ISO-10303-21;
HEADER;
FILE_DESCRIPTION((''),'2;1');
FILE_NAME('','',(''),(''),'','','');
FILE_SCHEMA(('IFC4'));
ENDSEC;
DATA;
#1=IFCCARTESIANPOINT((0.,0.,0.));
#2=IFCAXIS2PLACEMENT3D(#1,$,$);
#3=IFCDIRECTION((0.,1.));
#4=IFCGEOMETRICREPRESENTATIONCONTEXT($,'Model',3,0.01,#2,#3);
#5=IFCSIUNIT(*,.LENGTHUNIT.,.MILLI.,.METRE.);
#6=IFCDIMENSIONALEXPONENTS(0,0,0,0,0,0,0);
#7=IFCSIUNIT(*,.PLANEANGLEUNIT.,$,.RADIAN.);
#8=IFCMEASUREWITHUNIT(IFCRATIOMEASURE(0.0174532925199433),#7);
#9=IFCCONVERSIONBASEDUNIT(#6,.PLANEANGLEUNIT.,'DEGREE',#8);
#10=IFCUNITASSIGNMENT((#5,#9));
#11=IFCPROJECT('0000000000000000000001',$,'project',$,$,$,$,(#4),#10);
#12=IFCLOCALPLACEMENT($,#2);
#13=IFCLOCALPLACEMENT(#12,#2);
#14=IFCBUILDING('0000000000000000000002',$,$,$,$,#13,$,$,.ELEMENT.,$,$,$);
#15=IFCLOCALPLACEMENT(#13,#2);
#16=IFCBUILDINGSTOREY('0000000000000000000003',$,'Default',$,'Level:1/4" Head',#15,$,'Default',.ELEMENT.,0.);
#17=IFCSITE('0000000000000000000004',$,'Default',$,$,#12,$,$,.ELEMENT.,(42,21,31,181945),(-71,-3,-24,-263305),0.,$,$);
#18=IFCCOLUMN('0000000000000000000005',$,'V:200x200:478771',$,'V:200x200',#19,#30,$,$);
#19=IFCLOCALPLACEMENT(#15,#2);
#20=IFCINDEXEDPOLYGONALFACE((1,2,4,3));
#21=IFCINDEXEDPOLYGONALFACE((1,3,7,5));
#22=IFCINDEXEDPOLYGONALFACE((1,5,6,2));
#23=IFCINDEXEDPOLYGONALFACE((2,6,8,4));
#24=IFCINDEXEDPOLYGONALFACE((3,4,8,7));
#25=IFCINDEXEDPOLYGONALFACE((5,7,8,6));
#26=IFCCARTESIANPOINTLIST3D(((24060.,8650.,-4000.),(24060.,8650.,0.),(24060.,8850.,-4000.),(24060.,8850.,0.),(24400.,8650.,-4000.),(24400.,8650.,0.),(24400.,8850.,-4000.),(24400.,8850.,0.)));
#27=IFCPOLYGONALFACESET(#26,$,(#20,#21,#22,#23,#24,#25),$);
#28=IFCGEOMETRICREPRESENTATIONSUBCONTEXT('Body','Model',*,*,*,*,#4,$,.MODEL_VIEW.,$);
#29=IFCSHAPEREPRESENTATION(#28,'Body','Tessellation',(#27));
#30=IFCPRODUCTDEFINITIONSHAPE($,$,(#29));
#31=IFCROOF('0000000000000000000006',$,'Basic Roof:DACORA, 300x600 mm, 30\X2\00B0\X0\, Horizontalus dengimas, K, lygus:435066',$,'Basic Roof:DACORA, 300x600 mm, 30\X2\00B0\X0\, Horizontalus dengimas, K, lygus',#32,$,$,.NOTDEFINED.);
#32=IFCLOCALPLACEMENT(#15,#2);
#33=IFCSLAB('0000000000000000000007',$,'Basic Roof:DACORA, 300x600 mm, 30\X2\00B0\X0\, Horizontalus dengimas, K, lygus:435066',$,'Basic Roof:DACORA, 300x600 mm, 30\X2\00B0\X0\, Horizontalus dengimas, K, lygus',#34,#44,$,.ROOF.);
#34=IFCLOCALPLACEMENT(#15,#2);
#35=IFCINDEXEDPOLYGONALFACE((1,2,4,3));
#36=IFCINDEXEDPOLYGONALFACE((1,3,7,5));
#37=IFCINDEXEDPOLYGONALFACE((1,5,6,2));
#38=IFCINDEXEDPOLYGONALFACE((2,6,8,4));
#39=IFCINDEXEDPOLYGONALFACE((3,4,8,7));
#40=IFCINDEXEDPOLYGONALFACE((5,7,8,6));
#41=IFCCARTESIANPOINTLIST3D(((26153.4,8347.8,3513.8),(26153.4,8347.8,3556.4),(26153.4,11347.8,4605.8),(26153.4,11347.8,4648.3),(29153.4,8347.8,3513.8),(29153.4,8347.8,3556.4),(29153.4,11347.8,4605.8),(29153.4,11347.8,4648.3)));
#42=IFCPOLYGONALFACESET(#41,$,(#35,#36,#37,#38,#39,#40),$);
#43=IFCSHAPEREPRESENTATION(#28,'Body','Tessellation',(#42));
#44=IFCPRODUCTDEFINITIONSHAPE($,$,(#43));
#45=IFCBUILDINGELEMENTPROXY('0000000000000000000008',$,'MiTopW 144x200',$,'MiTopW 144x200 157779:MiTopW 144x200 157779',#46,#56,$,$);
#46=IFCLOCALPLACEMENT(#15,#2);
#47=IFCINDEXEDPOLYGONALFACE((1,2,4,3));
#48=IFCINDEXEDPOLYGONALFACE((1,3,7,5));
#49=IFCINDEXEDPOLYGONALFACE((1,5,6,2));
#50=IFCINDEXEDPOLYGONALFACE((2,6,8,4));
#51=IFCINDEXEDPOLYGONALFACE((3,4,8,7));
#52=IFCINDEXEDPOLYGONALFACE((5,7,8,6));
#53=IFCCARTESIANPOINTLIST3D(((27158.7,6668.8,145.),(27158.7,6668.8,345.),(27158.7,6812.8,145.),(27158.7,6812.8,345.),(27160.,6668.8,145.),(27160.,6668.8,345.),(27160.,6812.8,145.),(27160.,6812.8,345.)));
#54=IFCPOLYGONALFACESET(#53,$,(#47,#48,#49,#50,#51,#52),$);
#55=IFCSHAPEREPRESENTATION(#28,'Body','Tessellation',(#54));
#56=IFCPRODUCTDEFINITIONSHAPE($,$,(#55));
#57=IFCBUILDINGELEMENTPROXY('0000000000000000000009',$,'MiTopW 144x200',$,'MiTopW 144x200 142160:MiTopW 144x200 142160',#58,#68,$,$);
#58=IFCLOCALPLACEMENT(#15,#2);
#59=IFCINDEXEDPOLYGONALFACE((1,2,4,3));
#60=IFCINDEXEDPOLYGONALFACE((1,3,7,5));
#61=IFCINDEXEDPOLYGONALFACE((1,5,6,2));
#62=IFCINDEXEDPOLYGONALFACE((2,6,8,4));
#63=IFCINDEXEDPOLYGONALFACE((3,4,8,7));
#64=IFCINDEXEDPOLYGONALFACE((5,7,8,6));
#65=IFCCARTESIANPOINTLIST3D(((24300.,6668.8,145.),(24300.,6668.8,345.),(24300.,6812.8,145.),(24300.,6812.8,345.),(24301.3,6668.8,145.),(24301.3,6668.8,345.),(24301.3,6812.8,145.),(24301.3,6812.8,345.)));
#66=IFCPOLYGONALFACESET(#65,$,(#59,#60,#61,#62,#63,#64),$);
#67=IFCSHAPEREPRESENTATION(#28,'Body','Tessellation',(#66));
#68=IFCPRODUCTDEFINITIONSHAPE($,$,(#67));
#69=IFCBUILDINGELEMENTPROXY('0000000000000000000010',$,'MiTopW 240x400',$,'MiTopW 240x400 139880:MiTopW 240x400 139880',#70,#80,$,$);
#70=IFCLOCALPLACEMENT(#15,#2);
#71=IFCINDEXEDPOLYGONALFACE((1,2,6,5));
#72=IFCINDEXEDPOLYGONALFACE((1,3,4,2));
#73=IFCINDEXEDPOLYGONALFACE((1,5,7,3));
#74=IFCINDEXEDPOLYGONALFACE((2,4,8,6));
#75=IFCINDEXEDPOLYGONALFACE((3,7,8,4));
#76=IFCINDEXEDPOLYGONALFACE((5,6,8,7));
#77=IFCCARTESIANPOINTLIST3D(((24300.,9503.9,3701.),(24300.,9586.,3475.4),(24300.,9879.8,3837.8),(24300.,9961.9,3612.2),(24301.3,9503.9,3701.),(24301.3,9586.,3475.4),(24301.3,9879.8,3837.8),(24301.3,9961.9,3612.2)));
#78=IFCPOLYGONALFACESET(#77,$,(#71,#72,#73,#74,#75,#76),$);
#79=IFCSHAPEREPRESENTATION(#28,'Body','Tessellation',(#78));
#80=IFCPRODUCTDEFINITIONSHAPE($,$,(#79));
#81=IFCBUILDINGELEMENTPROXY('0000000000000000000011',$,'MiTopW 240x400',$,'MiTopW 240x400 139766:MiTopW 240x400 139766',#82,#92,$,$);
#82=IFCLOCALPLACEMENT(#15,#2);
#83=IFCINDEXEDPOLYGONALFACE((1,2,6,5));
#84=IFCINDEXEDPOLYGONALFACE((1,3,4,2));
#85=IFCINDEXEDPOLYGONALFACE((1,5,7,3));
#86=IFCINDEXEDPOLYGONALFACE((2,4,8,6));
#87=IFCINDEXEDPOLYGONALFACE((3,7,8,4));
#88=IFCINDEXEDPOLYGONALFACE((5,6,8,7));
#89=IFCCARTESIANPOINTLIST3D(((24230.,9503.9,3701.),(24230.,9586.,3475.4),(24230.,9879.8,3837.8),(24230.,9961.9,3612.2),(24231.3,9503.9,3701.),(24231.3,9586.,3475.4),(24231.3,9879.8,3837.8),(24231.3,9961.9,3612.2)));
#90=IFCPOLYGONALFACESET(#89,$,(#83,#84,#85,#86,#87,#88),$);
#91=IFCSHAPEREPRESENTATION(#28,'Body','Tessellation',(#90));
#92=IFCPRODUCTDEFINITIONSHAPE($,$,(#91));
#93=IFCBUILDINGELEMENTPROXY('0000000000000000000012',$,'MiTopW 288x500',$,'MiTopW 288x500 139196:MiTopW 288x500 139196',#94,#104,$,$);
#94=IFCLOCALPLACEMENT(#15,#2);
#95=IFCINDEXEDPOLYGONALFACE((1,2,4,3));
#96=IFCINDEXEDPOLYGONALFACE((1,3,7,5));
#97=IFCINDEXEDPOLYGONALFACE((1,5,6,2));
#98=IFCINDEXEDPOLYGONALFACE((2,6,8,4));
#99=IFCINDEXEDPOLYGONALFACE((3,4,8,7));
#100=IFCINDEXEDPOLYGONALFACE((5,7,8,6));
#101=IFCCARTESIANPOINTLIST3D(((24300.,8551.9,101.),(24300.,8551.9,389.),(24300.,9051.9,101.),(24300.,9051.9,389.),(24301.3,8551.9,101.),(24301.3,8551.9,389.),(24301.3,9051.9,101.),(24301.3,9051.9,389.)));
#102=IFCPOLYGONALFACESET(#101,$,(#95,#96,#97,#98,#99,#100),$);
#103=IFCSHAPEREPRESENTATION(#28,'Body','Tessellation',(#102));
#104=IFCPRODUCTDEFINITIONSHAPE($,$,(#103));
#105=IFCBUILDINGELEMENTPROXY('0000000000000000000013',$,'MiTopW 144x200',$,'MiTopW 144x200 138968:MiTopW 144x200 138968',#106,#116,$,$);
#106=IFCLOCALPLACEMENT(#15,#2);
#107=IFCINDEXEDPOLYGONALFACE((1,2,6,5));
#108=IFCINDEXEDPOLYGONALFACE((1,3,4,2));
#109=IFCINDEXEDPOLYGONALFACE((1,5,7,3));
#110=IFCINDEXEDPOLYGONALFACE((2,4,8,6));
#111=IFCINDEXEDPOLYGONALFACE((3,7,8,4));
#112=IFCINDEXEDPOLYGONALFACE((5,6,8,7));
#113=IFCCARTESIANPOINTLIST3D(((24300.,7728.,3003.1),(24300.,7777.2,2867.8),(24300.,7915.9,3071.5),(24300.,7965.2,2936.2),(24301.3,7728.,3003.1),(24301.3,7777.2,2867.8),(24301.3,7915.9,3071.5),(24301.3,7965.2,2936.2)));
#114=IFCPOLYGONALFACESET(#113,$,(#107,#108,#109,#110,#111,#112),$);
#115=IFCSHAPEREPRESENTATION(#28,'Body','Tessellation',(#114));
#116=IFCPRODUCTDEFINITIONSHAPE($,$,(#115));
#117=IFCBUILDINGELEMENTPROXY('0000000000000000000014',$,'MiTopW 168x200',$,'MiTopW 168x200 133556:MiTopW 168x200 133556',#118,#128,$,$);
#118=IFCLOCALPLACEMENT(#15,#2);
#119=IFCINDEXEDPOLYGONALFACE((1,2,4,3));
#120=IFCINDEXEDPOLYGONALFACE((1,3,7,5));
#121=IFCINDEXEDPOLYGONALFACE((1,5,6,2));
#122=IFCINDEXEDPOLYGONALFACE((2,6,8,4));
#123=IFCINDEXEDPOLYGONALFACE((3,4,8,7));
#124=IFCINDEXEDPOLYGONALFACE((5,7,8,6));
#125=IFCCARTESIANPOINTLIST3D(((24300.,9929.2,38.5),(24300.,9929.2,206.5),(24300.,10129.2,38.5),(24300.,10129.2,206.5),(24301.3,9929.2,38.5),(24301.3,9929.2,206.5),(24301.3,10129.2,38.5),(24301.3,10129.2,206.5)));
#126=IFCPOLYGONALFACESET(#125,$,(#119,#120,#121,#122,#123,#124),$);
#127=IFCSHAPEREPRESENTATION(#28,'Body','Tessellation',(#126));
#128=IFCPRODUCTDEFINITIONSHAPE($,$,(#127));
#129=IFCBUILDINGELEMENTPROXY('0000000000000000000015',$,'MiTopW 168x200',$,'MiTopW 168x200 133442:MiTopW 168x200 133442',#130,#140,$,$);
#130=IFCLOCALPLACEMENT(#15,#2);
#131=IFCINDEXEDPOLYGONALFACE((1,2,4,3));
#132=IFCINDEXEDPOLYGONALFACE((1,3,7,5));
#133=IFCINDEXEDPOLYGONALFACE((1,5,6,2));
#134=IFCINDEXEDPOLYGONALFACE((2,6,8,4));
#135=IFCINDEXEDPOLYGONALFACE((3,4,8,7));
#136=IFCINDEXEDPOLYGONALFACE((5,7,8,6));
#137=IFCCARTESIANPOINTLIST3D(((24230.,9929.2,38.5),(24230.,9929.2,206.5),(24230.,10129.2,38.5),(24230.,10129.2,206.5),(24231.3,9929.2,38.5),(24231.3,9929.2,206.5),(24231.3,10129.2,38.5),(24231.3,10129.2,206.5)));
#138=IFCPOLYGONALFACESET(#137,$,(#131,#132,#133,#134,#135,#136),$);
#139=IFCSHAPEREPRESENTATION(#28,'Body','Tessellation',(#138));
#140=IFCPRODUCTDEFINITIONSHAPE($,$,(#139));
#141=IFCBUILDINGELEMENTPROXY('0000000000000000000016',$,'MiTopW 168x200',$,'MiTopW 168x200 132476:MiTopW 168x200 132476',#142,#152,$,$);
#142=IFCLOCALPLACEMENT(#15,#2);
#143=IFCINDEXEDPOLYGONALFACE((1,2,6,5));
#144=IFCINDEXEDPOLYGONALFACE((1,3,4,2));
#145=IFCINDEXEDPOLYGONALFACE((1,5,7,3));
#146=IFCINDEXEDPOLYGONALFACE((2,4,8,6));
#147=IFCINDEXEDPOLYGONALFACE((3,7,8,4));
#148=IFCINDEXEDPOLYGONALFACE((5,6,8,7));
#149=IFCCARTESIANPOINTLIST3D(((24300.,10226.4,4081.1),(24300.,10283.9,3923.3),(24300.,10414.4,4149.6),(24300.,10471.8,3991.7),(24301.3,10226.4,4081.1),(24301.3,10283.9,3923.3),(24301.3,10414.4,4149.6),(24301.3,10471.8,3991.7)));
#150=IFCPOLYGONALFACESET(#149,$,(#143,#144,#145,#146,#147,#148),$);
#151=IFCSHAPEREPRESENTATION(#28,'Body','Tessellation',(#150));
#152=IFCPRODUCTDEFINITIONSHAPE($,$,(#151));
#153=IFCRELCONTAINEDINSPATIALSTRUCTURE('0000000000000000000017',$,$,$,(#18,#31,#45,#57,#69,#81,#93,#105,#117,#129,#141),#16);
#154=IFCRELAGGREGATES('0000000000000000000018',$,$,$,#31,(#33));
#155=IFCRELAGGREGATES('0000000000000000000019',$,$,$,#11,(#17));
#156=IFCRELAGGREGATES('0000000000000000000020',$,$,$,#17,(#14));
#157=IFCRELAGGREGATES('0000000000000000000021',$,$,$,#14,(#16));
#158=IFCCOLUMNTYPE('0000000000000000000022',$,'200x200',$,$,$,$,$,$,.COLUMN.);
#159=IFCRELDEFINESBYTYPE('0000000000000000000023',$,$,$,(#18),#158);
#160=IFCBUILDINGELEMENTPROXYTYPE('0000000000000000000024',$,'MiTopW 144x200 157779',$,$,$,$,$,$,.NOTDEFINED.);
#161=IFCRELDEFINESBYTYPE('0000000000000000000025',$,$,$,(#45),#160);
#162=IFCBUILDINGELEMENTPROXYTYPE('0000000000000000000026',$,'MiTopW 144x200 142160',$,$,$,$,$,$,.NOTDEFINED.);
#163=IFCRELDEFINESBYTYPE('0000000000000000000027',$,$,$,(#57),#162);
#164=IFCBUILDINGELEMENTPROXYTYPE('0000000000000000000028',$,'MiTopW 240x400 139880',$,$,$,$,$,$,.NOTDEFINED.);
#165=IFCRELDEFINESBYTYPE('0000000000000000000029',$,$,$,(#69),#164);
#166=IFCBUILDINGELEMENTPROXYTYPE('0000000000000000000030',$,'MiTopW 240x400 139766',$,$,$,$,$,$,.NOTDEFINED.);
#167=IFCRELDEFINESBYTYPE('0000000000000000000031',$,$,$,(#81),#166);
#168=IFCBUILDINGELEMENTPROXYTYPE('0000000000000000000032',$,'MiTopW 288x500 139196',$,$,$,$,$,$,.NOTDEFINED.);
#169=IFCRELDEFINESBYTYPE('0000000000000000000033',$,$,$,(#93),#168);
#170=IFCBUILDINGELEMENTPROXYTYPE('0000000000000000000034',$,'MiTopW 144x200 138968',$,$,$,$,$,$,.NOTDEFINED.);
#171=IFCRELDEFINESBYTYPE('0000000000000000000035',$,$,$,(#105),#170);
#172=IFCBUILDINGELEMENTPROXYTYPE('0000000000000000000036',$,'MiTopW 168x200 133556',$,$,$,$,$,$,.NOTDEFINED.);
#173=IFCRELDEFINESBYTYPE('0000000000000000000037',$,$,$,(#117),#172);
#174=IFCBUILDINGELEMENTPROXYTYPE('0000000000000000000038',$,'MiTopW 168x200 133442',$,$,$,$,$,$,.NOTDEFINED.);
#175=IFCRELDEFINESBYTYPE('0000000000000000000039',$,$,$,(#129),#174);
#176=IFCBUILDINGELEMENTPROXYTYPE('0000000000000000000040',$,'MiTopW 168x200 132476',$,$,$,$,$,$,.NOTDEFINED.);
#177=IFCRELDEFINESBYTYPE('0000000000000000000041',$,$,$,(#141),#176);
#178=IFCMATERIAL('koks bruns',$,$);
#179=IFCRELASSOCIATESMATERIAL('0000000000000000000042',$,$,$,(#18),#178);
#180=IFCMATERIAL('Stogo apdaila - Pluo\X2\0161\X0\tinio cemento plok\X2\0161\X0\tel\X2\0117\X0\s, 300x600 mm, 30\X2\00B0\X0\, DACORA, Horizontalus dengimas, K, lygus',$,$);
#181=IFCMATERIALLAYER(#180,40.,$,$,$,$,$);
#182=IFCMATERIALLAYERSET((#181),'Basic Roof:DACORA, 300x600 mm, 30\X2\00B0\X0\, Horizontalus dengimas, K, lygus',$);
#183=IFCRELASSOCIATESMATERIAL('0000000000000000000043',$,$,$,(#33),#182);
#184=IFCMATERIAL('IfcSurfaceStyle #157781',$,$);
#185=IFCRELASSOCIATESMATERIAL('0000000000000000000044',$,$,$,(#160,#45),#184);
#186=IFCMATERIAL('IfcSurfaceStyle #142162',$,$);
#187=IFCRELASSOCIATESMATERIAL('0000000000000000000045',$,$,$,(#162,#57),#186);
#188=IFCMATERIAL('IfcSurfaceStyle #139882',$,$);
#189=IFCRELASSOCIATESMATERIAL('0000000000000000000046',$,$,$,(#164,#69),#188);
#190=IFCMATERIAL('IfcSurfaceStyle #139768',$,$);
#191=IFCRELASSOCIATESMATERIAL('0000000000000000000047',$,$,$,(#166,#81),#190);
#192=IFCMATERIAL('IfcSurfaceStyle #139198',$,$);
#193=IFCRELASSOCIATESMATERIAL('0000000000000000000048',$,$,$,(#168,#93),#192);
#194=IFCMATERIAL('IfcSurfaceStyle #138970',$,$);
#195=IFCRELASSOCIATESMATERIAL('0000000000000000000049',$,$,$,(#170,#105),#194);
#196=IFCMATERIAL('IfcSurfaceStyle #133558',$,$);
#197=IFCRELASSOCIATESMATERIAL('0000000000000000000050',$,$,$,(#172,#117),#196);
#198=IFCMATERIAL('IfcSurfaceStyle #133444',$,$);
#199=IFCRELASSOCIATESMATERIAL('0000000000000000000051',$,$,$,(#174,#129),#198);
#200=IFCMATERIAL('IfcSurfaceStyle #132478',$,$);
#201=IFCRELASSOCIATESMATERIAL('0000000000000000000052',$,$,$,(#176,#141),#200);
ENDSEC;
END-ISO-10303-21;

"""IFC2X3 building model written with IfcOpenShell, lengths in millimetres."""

from ifc_helpers import new_model, entity, si_unit, converted_unit, direction, frame, frame_2d, origin, origin_2d_with_axis, place, context, subcontext, project, spatial, polyline, rectangle, outline, extrude, source, transform, mapped, material, layer, layer_set, type_object, type_shapes, element, aggregate, save


model = new_model("IFC2X3")

# Units and contexts
model_context = context("Model", 3, precision=0.01, world=origin(), true_north=direction((0.0, 1.0)))
body_context = subcontext(model_context, "Body", "Model", "MODEL_VIEW")
ifc_project = project(units=[si_unit("LENGTHUNIT", "METRE", prefix="MILLI"), converted_unit("PLANEANGLEUNIT", "DEGREE", entity("IfcRatioMeasure", 0.0174532925199433), si_unit("PLANEANGLEUNIT", "RADIAN"), dimensions=[0, 0, 0, 0, 0, 0, 0])], contexts=[model_context])

# Site, building, storey
site_placement = place(None, origin())
site = spatial("IfcSite", under=ifc_project, at=site_placement, Name="Default", CompositionType="ELEMENT", RefLatitude=(42, 21, 31, 181945), RefLongitude=(-71, -3, -24, -263305), RefElevation=0.0)
building_placement = place(site_placement, origin())
building = spatial("IfcBuilding", under=site, at=building_placement, CompositionType="ELEMENT")
storey_placement = place(building_placement, origin())
storey = spatial("IfcBuildingStorey", under=building, at=storey_placement, Name="Default", ObjectType="Level:1/4\" Head", LongName="Default", CompositionType="ELEMENT", Elevation=0.0)

# Column
ifc_material_1 = material(Name="koks bruns")
column_type_1 = type_object("IfcColumnType", Name="200x200", PredefinedType="COLUMN")
shared_shape_1 = source(origin(), body_context, "Body", "SweptSolid", [
    extrude(rectangle(XDim=340.0, YDim=200.0, at=origin_2d_with_axis()), frame((100.0, 280.0, -4000.0), z_axis=(0.0, 0.0, 1.0), x_axis=(0.0, -1.0, 0.0)), (0.0, 0.0, 1.0), 4000.0),
])
type_shapes(column_type_1, [shared_shape_1])
column_placement = place(storey_placement, frame((24510.0, 8650.0, 0.0), z_axis=(0.0, 0.0, 1.0), x_axis=(0.0, 1.0, 0.0)))
element("IfcColumn", 1, at=column_placement, inside=storey, type_object=column_type_1, material=ifc_material_1, Name="V:200x200:478771", ObjectType="V:200x200", context=body_context, shape_type="MappedRepresentation", body=[
    mapped(shared_shape_1, transform((0.0, 0.0, 0.0), scale=1.0)),
])

# Roof, slab
roof_placement = place(storey_placement, frame((26153.4, 8347.8, 3513.8)))
roof = element("IfcRoof", 2, at=roof_placement, inside=storey, Name="Basic Roof:DACORA, 300x600 mm, 30°, Horizontalus dengimas, K, lygus:435066", ObjectType="Basic Roof:DACORA, 300x600 mm, 30°, Horizontalus dengimas, K, lygus", ShapeType="NOTDEFINED")
ifc_material_2 = material(Name="Stogo apdaila - Pluoštinio cemento plokštelės, 300x600 mm, 30°, DACORA, Horizontalus dengimas, K, lygus")
ifc_layer = layer(ifc_material_2, 40.0)
ifc_layer_set = layer_set([ifc_layer], Name="Basic Roof:DACORA, 300x600 mm, 30°, Horizontalus dengimas, K, lygus")
slab_placement = place(roof_placement, origin())
slab = element("IfcSlab", 3, at=slab_placement, material=ifc_layer_set, Name="Basic Roof:DACORA, 300x600 mm, 30°, Horizontalus dengimas, K, lygus:435066", ObjectType="Basic Roof:DACORA, 300x600 mm, 30°, Horizontalus dengimas, K, lygus", PredefinedType="ROOF", context=body_context, shape_type="SweptSolid", body=[
    extrude(rectangle(XDim=3192.5, YDim=3000.0, at=frame_2d((0.0, 0.0), x_axis=(0.0, -1.0))), frame((1500.0, 1500.0, 546.0), z_axis=(0.0, -0.34202, 0.939693), x_axis=(1.0, 0.0, 0.0)), (0.0, 0.34202, 0.939693), 42.6),
])
aggregate(roof, [slab])

# Building element proxies
ifc_material_3 = material(Name="IfcSurfaceStyle #157781")
building_element_proxy_type_1 = type_object("IfcBuildingElementProxyType", Name="MiTopW 144x200 157779", PredefinedType="NOTDEFINED", material=ifc_material_3)
shared_shape_2 = source(origin(), body_context, "Body", "SweptSolid", [
    extrude(rectangle(XDim=200.0, YDim=144.0, at=frame_2d((0.0, 0.0), x_axis=(1.0, 0.0))), frame((100.0, 72.0, 0.0), z_axis=(0.0, 0.0, 1.0), x_axis=(-1.0, 0.0, 0.0)), (0.0, 0.0, 1.0), 1.3),
])
type_shapes(building_element_proxy_type_1, [shared_shape_2])
proxy_1_placement = place(building_placement, frame((27160.0, 6668.8, 145.0), z_axis=(-1.0, 0.0, 0.0), x_axis=(0.0, 0.0, 1.0)))
element("IfcBuildingElementProxy", 4, at=proxy_1_placement, inside=storey, type_object=building_element_proxy_type_1, material=ifc_material_3, Name="MiTopW 144x200", ObjectType="MiTopW 144x200 157779:MiTopW 144x200 157779", context=body_context, shape_type="MappedRepresentation", body=[
    mapped(shared_shape_2, transform((0.0, 0.0, 0.0), scale=1.0)),
])
ifc_material_4 = material(Name="IfcSurfaceStyle #142162")
building_element_proxy_type_2 = type_object("IfcBuildingElementProxyType", Name="MiTopW 144x200 142160", PredefinedType="NOTDEFINED", material=ifc_material_4)
shared_shape_3 = source(origin(), body_context, "Body", "SweptSolid", [
    extrude(rectangle(XDim=200.0, YDim=144.0, at=frame_2d((0.0, 0.0), x_axis=(1.0, 0.0))), frame((100.0, 72.0, 0.0), z_axis=(0.0, 0.0, 1.0), x_axis=(-1.0, 0.0, 0.0)), (0.0, 0.0, 1.0), 1.3),
])
type_shapes(building_element_proxy_type_2, [shared_shape_3])
proxy_2_placement = place(building_placement, frame((24301.3, 6668.8, 145.0), z_axis=(-1.0, 0.0, 0.0), x_axis=(0.0, 0.0, 1.0)))
element("IfcBuildingElementProxy", 5, at=proxy_2_placement, inside=storey, type_object=building_element_proxy_type_2, material=ifc_material_4, Name="MiTopW 144x200", ObjectType="MiTopW 144x200 142160:MiTopW 144x200 142160", context=body_context, shape_type="MappedRepresentation", body=[
    mapped(shared_shape_3, transform((0.0, 0.0, 0.0), scale=1.0)),
])
ifc_material_5 = material(Name="IfcSurfaceStyle #139882")
building_element_proxy_type_3 = type_object("IfcBuildingElementProxyType", Name="MiTopW 240x400 139880", PredefinedType="NOTDEFINED", material=ifc_material_5)
shared_shape_4 = source(origin(), body_context, "Body", "SweptSolid", [
    extrude(outline(polyline([(-200.0, -120.0), (200.0, -120.0), (200.0, 120.0), (-200.0, 120.0), (-200.0, -120.0)])), frame((200.0, 120.0, 0.0), z_axis=(0.0, 0.0, 1.0), x_axis=(-1.0, 0.0, 0.0)), (0.0, 0.0, 1.0), 1.3),
])
type_shapes(building_element_proxy_type_3, [shared_shape_4])
proxy_3_placement = place(building_placement, frame((24301.3, 9961.9, 3612.2), z_axis=(-1.0, 0.0, 0.0), x_axis=(0.0, -0.939693, -0.34202)))
element("IfcBuildingElementProxy", 6, at=proxy_3_placement, inside=storey, type_object=building_element_proxy_type_3, material=ifc_material_5, Name="MiTopW 240x400", ObjectType="MiTopW 240x400 139880:MiTopW 240x400 139880", context=body_context, shape_type="MappedRepresentation", body=[
    mapped(shared_shape_4, transform((0.0, 0.0, 0.0), scale=1.0)),
])
ifc_material_6 = material(Name="IfcSurfaceStyle #139768")
building_element_proxy_type_4 = type_object("IfcBuildingElementProxyType", Name="MiTopW 240x400 139766", PredefinedType="NOTDEFINED", material=ifc_material_6)
shared_shape_5 = source(origin(), body_context, "Body", "SweptSolid", [
    extrude(outline(polyline([(-200.0, -120.0), (200.0, -120.0), (200.0, 120.0), (-200.0, 120.0), (-200.0, -120.0)])), frame((200.0, 120.0, 0.0), z_axis=(0.0, 0.0, 1.0), x_axis=(-1.0, 0.0, 0.0)), (0.0, 0.0, 1.0), 1.3),
])
type_shapes(building_element_proxy_type_4, [shared_shape_5])
proxy_4_placement = place(building_placement, frame((24231.3, 9961.9, 3612.2), z_axis=(-1.0, 0.0, 0.0), x_axis=(0.0, -0.939693, -0.34202)))
element("IfcBuildingElementProxy", 7, at=proxy_4_placement, inside=storey, type_object=building_element_proxy_type_4, material=ifc_material_6, Name="MiTopW 240x400", ObjectType="MiTopW 240x400 139766:MiTopW 240x400 139766", context=body_context, shape_type="MappedRepresentation", body=[
    mapped(shared_shape_5, transform((0.0, 0.0, 0.0), scale=1.0)),
])
ifc_material_7 = material(Name="IfcSurfaceStyle #139198")
building_element_proxy_type_5 = type_object("IfcBuildingElementProxyType", Name="MiTopW 288x500 139196", PredefinedType="NOTDEFINED", material=ifc_material_7)
shared_shape_6 = source(origin(), body_context, "Body", "SweptSolid", [
    extrude(rectangle(XDim=500.0, YDim=288.0, at=frame_2d((0.0, 0.0), x_axis=(1.0, 0.0))), frame((250.0, 144.0, 0.0), z_axis=(0.0, 0.0, 1.0), x_axis=(-1.0, 0.0, 0.0)), (0.0, 0.0, 1.0), 1.3),
])
type_shapes(building_element_proxy_type_5, [shared_shape_6])
proxy_5_placement = place(building_placement, frame((24301.3, 8551.9, 389.0), z_axis=(-1.0, 0.0, 0.0), x_axis=(0.0, 1.0, 0.0)))
element("IfcBuildingElementProxy", 8, at=proxy_5_placement, inside=storey, type_object=building_element_proxy_type_5, material=ifc_material_7, Name="MiTopW 288x500", ObjectType="MiTopW 288x500 139196:MiTopW 288x500 139196", context=body_context, shape_type="MappedRepresentation", body=[
    mapped(shared_shape_6, transform((0.0, 0.0, 0.0), scale=1.0)),
])
ifc_material_8 = material(Name="IfcSurfaceStyle #138970")
building_element_proxy_type_6 = type_object("IfcBuildingElementProxyType", Name="MiTopW 144x200 138968", PredefinedType="NOTDEFINED", material=ifc_material_8)
shared_shape_7 = source(origin(), body_context, "Body", "SweptSolid", [
    extrude(outline(polyline([(-100.0, -72.0), (100.0, -72.0), (100.0, 72.0), (-100.0, 72.0), (-100.0, -72.0)])), frame((100.0, 72.0, 0.0), z_axis=(0.0, 0.0, 1.0), x_axis=(-1.0, 0.0, 0.0)), (0.0, 0.0, 1.0), 1.3),
])
type_shapes(building_element_proxy_type_6, [shared_shape_7])
proxy_6_placement = place(building_placement, frame((24301.3, 7965.2, 2936.2), z_axis=(-1.0, 0.0, 0.0), x_axis=(0.0, -0.939693, -0.34202)))
element("IfcBuildingElementProxy", 9, at=proxy_6_placement, inside=storey, type_object=building_element_proxy_type_6, material=ifc_material_8, Name="MiTopW 144x200", ObjectType="MiTopW 144x200 138968:MiTopW 144x200 138968", context=body_context, shape_type="MappedRepresentation", body=[
    mapped(shared_shape_7, transform((0.0, 0.0, 0.0), scale=1.0)),
])
ifc_material_9 = material(Name="IfcSurfaceStyle #133558")
building_element_proxy_type_7 = type_object("IfcBuildingElementProxyType", Name="MiTopW 168x200 133556", PredefinedType="NOTDEFINED", material=ifc_material_9)
shared_shape_8 = source(origin(), body_context, "Body", "SweptSolid", [
    extrude(rectangle(XDim=200.0, YDim=168.0, at=origin_2d_with_axis()), frame((100.0, 84.0, 0.0), z_axis=(0.0, 0.0, 1.0), x_axis=(-1.0, 0.0, 0.0)), (0.0, 0.0, 1.0), 1.3),
])
type_shapes(building_element_proxy_type_7, [shared_shape_8])
proxy_7_placement = place(building_placement, frame((24301.3, 9929.2, 206.5), z_axis=(-1.0, 0.0, 0.0), x_axis=(0.0, 1.0, 0.0)))
element("IfcBuildingElementProxy", 10, at=proxy_7_placement, inside=storey, type_object=building_element_proxy_type_7, material=ifc_material_9, Name="MiTopW 168x200", ObjectType="MiTopW 168x200 133556:MiTopW 168x200 133556", context=body_context, shape_type="MappedRepresentation", body=[
    mapped(shared_shape_8, transform((0.0, 0.0, 0.0), scale=1.0)),
])
ifc_material_10 = material(Name="IfcSurfaceStyle #133444")
building_element_proxy_type_8 = type_object("IfcBuildingElementProxyType", Name="MiTopW 168x200 133442", PredefinedType="NOTDEFINED", material=ifc_material_10)
shared_shape_9 = source(origin(), body_context, "Body", "SweptSolid", [
    extrude(rectangle(XDim=200.0, YDim=168.0, at=origin_2d_with_axis()), frame((100.0, 84.0, 0.0), z_axis=(0.0, 0.0, 1.0), x_axis=(-1.0, 0.0, 0.0)), (0.0, 0.0, 1.0), 1.3),
])
type_shapes(building_element_proxy_type_8, [shared_shape_9])
proxy_8_placement = place(building_placement, frame((24231.3, 9929.2, 206.5), z_axis=(-1.0, 0.0, 0.0), x_axis=(0.0, 1.0, 0.0)))
element("IfcBuildingElementProxy", 11, at=proxy_8_placement, inside=storey, type_object=building_element_proxy_type_8, material=ifc_material_10, Name="MiTopW 168x200", ObjectType="MiTopW 168x200 133442:MiTopW 168x200 133442", context=body_context, shape_type="MappedRepresentation", body=[
    mapped(shared_shape_9, transform((0.0, 0.0, 0.0), scale=1.0)),
])
ifc_material_11 = material(Name="IfcSurfaceStyle #132478")
building_element_proxy_type_9 = type_object("IfcBuildingElementProxyType", Name="MiTopW 168x200 132476", PredefinedType="NOTDEFINED", material=ifc_material_11)
shared_shape_10 = source(origin(), body_context, "Body", "SweptSolid", [
    extrude(outline(polyline([(-100.0, -84.0), (100.0, -84.0), (100.0, 84.0), (-100.0, 84.0), (-100.0, -84.0)])), frame((100.0, 84.0, 0.0), z_axis=(0.0, 0.0, 1.0), x_axis=(-1.0, 0.0, 0.0)), (0.0, 0.0, 1.0), 1.3),
])
type_shapes(building_element_proxy_type_9, [shared_shape_10])
proxy_9_placement = place(building_placement, frame((24301.3, 10226.4, 4081.1), z_axis=(-1.0, 0.0, 0.0), x_axis=(0.0, 0.939693, 0.34202)))
element("IfcBuildingElementProxy", 12, at=proxy_9_placement, inside=storey, type_object=building_element_proxy_type_9, material=ifc_material_11, Name="MiTopW 168x200", ObjectType="MiTopW 168x200 132476:MiTopW 168x200 132476", context=body_context, shape_type="MappedRepresentation", body=[
    mapped(shared_shape_10, transform((0.0, 0.0, 0.0), scale=1.0)),
])

save(model, "model.ifc")
